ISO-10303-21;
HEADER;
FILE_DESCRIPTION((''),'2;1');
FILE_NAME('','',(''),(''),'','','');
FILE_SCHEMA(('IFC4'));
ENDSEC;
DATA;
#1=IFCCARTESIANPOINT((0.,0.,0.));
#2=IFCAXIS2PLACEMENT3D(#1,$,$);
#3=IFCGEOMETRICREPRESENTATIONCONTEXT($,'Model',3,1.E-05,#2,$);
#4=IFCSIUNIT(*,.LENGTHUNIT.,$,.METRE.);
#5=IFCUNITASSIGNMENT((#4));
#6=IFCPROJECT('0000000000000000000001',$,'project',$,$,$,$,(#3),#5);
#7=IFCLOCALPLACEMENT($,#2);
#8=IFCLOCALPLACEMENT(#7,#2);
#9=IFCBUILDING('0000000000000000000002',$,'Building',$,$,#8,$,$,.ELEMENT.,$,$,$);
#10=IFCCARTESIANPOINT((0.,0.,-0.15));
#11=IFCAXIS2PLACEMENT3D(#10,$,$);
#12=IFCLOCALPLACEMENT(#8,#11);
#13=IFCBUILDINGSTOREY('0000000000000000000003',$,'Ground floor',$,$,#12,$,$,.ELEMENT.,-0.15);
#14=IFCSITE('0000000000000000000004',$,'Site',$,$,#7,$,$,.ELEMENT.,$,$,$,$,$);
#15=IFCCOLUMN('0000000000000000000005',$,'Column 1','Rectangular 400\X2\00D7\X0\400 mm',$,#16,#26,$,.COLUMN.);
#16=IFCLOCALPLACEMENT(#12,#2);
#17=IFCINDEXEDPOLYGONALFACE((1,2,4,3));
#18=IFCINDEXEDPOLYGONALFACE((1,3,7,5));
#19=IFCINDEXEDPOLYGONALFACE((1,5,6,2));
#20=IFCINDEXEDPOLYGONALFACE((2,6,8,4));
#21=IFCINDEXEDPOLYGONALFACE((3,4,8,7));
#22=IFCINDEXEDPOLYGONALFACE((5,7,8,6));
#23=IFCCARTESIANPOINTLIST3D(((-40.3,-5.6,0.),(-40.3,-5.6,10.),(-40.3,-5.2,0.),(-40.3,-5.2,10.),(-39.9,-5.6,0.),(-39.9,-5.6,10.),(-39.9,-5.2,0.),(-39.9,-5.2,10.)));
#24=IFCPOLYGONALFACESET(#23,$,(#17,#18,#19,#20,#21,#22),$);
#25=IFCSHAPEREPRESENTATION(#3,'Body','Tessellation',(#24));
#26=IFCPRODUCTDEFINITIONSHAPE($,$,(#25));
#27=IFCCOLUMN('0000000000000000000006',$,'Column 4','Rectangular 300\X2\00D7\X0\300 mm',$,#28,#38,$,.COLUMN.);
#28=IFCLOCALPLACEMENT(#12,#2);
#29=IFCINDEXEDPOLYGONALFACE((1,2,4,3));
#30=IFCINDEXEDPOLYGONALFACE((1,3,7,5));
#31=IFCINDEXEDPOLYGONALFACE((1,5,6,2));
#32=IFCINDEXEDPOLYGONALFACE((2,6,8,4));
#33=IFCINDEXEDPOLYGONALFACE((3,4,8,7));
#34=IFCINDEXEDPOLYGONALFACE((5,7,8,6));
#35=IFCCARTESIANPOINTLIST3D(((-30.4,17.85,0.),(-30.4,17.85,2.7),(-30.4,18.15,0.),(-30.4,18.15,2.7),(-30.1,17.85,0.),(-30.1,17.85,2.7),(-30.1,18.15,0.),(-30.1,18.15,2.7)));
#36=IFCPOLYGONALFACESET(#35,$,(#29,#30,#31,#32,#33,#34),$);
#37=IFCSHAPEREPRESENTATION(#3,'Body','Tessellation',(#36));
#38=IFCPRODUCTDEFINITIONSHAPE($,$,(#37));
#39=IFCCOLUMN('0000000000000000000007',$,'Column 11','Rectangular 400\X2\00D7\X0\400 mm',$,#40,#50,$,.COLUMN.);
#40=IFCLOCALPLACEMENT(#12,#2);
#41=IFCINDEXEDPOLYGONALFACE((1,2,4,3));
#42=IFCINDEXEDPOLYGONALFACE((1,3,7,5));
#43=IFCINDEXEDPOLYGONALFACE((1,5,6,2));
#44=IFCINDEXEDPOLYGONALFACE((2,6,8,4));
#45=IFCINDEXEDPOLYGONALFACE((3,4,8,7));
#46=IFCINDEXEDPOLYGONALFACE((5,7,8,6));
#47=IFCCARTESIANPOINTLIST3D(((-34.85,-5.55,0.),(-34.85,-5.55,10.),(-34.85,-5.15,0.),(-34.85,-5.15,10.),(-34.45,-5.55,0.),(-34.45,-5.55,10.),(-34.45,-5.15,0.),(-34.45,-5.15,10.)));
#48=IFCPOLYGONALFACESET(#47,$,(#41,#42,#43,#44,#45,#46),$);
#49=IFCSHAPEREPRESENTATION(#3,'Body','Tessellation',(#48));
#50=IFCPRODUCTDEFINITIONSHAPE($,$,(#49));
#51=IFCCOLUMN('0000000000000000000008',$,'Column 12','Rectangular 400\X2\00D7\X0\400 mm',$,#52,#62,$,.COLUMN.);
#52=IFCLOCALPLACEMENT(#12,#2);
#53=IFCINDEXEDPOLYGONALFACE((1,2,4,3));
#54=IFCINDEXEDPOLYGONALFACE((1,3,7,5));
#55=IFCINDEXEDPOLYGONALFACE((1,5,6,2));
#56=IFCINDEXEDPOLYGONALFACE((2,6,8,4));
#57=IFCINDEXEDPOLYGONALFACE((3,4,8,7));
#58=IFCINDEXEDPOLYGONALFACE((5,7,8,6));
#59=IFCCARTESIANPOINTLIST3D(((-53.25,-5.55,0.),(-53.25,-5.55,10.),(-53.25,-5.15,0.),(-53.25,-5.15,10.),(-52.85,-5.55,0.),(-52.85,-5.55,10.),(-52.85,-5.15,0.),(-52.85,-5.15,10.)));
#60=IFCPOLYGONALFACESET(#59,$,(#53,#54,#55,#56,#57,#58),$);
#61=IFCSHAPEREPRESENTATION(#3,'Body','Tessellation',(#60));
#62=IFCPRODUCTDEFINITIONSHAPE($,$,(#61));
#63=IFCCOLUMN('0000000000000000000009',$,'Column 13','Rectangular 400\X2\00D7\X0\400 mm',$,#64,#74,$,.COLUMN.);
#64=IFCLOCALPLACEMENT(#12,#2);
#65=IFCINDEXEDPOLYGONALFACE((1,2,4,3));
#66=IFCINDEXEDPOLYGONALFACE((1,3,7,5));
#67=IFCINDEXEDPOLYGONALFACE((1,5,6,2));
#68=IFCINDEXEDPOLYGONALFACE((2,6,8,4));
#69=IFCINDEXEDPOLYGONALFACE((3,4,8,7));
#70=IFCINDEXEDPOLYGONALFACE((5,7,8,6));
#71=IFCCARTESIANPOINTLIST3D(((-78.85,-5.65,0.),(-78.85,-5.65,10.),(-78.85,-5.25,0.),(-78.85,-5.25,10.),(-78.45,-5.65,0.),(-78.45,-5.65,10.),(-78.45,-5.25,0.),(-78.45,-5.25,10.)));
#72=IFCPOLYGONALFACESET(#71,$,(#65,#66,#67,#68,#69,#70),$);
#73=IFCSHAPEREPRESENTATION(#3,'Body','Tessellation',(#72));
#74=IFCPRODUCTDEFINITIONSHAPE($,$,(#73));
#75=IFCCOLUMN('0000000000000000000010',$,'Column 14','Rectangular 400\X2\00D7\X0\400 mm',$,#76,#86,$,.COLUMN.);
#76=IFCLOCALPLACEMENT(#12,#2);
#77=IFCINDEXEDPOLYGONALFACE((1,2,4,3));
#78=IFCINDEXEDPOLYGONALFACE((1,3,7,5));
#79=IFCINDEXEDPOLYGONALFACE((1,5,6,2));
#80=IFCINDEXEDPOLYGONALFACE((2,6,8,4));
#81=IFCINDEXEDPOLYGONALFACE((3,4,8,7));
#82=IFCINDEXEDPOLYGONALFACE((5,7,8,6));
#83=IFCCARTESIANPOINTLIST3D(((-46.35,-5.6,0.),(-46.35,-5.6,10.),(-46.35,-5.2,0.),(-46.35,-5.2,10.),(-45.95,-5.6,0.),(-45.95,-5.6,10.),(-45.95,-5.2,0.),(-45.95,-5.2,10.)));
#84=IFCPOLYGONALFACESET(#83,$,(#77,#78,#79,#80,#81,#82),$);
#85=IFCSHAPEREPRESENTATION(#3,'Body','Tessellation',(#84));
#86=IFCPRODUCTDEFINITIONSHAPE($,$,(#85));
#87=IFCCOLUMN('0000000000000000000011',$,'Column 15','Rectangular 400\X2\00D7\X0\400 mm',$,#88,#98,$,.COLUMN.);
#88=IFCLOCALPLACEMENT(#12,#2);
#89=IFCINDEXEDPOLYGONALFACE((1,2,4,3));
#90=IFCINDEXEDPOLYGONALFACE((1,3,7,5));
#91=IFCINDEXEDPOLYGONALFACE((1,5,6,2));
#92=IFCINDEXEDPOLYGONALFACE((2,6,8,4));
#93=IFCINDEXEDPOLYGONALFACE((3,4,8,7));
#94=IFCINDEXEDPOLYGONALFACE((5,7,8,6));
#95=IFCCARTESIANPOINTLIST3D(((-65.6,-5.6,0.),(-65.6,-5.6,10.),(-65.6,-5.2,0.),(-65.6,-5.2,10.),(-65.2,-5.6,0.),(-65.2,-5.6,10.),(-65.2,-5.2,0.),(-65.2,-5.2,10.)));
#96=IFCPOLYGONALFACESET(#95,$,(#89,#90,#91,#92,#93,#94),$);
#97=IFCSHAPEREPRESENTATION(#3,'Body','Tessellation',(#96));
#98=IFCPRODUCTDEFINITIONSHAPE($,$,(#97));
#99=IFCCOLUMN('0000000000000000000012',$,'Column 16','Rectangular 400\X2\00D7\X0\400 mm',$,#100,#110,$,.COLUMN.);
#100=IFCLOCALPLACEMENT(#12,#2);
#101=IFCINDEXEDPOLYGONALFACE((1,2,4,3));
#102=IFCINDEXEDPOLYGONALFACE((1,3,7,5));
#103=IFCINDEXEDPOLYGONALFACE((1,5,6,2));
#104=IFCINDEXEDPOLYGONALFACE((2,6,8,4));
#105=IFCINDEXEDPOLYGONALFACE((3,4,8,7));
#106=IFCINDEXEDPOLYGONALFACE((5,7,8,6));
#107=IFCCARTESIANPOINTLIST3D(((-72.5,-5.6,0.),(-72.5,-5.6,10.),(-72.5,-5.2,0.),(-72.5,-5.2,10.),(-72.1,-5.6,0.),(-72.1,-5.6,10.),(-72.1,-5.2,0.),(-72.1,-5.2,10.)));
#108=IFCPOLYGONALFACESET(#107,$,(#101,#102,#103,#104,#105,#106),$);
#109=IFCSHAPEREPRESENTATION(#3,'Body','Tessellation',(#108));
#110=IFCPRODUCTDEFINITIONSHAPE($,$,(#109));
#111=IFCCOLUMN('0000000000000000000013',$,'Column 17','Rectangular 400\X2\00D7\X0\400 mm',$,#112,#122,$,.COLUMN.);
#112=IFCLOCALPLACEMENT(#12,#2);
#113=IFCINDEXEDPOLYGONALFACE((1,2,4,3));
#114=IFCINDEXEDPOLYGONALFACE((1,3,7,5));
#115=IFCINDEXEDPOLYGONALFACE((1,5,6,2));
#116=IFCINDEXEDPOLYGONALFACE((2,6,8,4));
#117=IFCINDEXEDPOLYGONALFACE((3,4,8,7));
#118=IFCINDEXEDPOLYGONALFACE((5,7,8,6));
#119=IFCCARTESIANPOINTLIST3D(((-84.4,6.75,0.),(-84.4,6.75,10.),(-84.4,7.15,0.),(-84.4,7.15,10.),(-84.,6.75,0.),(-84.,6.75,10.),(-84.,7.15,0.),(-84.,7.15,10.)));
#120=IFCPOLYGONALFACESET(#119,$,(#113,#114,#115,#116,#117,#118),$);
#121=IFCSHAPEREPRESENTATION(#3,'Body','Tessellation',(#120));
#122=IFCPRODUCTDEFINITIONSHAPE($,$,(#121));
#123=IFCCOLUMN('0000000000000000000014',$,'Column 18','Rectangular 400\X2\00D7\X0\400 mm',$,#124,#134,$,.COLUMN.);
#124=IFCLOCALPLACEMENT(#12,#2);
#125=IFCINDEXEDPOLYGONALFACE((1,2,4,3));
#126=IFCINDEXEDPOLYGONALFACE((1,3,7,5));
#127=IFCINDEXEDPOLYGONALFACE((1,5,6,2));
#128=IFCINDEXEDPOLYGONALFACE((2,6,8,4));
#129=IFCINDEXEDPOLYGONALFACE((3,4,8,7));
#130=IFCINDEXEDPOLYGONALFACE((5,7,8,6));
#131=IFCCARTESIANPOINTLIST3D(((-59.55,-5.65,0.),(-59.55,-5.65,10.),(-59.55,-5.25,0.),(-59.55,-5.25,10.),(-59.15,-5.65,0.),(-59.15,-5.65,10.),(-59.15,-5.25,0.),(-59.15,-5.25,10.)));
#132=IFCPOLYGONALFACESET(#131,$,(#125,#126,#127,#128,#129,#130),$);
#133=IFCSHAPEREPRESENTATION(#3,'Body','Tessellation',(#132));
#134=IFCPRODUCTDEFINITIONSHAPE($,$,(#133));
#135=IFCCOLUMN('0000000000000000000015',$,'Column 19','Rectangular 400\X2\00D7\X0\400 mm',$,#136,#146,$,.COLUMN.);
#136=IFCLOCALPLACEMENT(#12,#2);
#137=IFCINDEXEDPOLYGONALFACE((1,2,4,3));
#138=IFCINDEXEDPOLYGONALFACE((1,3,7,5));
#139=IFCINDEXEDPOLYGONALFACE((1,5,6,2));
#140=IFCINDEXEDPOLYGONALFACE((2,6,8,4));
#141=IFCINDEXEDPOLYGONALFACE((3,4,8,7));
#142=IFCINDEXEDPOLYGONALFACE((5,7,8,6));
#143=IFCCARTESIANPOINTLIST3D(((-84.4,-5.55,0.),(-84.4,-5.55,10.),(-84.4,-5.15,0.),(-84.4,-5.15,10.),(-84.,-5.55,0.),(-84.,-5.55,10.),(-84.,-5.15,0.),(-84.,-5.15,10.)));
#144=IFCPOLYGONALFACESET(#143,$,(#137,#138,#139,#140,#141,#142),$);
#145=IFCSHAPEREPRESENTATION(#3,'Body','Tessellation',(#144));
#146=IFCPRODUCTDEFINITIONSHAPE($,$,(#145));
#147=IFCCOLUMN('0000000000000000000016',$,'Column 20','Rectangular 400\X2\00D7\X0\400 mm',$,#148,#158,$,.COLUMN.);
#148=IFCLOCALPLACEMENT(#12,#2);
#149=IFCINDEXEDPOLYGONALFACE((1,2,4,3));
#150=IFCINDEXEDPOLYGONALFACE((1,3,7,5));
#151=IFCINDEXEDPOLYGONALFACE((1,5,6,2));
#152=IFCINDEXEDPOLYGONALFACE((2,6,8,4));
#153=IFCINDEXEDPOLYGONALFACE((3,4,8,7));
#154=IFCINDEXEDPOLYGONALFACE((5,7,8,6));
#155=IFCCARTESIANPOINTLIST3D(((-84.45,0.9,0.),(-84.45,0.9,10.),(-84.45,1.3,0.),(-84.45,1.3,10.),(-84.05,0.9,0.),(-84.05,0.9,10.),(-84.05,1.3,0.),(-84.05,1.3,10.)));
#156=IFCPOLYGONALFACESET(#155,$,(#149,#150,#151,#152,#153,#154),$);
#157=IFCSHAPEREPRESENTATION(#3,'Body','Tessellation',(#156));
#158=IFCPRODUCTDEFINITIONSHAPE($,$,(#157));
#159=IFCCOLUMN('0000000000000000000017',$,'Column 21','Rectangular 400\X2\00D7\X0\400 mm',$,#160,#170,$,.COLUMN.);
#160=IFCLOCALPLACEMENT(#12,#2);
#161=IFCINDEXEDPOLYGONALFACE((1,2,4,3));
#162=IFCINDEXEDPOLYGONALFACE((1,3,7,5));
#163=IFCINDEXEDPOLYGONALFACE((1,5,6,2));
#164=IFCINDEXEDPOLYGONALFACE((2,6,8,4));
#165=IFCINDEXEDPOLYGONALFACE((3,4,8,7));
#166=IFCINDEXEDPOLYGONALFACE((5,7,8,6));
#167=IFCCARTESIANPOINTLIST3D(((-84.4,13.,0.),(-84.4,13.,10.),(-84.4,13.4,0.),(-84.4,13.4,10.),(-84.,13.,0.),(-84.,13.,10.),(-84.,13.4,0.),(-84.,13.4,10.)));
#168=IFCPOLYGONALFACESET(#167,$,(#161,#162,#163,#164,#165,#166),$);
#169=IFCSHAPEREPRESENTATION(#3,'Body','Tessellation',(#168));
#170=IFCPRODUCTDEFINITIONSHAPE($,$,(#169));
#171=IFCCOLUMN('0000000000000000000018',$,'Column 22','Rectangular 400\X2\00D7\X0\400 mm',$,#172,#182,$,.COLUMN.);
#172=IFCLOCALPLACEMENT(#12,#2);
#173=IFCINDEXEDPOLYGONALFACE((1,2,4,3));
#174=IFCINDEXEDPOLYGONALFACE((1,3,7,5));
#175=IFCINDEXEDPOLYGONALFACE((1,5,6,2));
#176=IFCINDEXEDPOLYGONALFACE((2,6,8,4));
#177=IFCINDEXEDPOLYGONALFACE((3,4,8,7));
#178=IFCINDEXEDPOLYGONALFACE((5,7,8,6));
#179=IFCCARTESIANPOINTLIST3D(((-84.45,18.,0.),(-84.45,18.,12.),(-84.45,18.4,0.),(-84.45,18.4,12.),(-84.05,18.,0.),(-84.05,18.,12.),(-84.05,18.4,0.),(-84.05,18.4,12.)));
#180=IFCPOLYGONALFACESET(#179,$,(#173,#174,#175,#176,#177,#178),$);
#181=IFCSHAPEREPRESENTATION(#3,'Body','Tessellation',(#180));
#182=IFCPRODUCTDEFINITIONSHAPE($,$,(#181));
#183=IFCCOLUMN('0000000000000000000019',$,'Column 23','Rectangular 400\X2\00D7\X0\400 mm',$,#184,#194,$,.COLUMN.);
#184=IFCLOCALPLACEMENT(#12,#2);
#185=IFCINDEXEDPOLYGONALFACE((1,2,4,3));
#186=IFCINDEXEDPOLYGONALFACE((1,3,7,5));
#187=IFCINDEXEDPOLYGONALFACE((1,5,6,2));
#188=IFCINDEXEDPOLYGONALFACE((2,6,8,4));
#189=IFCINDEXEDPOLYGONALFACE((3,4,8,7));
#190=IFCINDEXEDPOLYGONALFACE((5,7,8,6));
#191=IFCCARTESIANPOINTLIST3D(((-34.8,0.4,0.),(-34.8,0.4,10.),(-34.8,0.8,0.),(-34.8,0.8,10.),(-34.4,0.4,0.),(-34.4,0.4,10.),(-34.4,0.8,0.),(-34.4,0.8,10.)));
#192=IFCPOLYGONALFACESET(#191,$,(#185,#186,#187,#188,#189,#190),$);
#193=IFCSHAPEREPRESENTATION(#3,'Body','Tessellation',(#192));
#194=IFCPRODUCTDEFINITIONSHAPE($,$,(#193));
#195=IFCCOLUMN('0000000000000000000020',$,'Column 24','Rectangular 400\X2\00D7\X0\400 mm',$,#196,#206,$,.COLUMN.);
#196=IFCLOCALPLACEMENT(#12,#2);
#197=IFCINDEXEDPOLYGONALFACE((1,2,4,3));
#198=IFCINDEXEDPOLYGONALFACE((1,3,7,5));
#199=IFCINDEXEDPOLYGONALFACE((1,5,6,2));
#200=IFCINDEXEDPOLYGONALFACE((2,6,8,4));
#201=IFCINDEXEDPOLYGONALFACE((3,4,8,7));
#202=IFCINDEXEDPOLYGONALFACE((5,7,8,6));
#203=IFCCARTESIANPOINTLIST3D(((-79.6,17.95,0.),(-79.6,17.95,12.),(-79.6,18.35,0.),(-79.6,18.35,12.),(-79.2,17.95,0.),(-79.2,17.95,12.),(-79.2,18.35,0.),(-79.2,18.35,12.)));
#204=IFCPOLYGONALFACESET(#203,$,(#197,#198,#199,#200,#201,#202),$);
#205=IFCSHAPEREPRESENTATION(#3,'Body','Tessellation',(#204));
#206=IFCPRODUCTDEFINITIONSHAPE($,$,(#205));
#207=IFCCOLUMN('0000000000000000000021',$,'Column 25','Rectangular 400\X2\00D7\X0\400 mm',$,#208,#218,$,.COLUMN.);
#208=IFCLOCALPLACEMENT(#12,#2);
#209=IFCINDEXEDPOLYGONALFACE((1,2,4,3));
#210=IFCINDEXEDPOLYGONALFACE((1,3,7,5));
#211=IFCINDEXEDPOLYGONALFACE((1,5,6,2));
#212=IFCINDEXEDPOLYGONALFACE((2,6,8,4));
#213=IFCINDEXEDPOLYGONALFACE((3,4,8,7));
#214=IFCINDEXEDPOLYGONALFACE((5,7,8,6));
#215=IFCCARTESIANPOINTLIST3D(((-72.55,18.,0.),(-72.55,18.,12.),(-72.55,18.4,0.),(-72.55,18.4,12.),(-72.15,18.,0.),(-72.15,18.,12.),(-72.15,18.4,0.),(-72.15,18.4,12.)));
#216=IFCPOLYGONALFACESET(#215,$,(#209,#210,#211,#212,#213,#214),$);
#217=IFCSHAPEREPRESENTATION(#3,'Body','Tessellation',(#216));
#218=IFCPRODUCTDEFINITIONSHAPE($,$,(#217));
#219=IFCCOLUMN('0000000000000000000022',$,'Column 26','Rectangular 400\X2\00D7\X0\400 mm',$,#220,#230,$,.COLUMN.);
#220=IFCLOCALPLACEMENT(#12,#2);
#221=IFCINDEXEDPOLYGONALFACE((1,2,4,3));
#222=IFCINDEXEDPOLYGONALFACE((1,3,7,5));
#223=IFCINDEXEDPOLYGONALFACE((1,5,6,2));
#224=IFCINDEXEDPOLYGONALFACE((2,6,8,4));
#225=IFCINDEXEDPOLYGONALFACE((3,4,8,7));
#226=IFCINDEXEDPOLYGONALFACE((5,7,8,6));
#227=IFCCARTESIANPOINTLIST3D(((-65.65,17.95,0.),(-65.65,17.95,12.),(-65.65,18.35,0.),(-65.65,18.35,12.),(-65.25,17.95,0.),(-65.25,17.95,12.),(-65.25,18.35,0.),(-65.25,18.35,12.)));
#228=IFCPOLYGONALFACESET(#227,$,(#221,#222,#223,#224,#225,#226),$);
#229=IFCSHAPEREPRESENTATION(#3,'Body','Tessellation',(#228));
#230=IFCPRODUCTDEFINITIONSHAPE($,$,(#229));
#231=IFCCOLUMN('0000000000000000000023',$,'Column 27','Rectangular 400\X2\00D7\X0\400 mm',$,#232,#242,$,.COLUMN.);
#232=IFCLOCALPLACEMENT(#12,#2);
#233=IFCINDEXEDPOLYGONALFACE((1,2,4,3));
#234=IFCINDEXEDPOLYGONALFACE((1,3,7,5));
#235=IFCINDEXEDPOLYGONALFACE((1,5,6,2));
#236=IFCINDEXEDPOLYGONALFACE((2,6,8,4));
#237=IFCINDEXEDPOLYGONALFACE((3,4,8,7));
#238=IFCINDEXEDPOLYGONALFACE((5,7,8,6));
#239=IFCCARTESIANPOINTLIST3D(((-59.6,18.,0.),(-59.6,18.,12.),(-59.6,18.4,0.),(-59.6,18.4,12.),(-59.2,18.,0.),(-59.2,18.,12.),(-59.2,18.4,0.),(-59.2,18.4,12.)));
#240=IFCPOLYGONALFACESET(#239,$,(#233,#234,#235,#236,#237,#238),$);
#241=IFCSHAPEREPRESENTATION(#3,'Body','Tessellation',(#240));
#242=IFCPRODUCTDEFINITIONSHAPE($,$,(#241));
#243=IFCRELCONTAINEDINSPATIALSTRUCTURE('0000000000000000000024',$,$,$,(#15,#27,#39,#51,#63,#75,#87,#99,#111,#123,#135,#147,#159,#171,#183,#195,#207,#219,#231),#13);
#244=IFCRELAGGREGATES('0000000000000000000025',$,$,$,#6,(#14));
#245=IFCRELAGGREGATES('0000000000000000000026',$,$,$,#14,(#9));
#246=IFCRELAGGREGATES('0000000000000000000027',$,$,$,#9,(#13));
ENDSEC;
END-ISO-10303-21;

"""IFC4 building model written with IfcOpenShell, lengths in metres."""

from ifc_helpers import new_model, si_unit, frame, origin, place, context, project, spatial, polyline, outline, extrude, element, save


model = new_model("IFC4")

# Units and contexts
model_context = context("Model", 3, precision=1e-05, world=origin())
ifc_project = project(units=[si_unit("LENGTHUNIT", "METRE")], contexts=[model_context])

# Site, building, storey
site_placement = place(None, origin())
site = spatial("IfcSite", under=ifc_project, at=site_placement, Name="Site", CompositionType="ELEMENT")
building_placement = place(site_placement, origin())
building = spatial("IfcBuilding", under=site, at=building_placement, Name="Building", CompositionType="ELEMENT")
storey_placement = place(building_placement, frame((0.0, 0.0, -0.15)))
storey = spatial("IfcBuildingStorey", under=building, at=storey_placement, Name="Ground floor", CompositionType="ELEMENT", Elevation=-0.15)

# Columns
column_1_placement = place(storey_placement, frame((-40.1, -5.4, 0.0), z_axis=(0.0, 0.0, 1.0), x_axis=(1.0, 0.0, 0.0)))
element("IfcColumn", 1, at=column_1_placement, inside=storey, Name="Column 1", Description="Rectangular 400×400 mm", PredefinedType="COLUMN", context=model_context, shape_type="SweptSolid", body=[
    extrude(outline(polyline([(-0.2, -0.2), (0.2, -0.2), (0.2, 0.2), (-0.2, 0.2), (-0.2, -0.2)])), origin(), (0.0, 0.0, 1.0), 10.0),
])
column_2_placement = place(storey_placement, frame((-30.25, 18.0, 0.0), z_axis=(0.0, 0.0, 1.0), x_axis=(1.0, 0.0, 0.0)))
element("IfcColumn", 2, at=column_2_placement, inside=storey, Name="Column 4", Description="Rectangular 300×300 mm", PredefinedType="COLUMN", context=model_context, shape_type="SweptSolid", body=[
    extrude(outline(polyline([(-0.15, -0.15), (0.15, -0.15), (0.15, 0.15), (-0.15, 0.15), (-0.15, -0.15)])), origin(), (0.0, 0.0, 1.0), 2.7),
])
for number, where, z_axis, x_axis, name in (
    (3, (-34.65, -5.35, 0.0), (0.0, 0.0, 1.0), (1.0, 0.0, 0.0), "Column 11"),
    (4, (-53.05, -5.35, 0.0), (0.0, 0.0, 1.0), (1.0, 0.0, 0.0), "Column 12"),
    (5, (-78.65, -5.45, 0.0), (0.0, 0.0, 1.0), (1.0, 0.0, 0.0), "Column 13"),
    (6, (-46.15, -5.4, 0.0), (0.0, 0.0, 1.0), (1.0, 0.0, 0.0), "Column 14"),
    (7, (-65.4, -5.4, 0.0), (0.0, 0.0, 1.0), (1.0, 0.0, 0.0), "Column 15"),
    (8, (-72.3, -5.4, 0.0), (0.0, 0.0, 1.0), (1.0, 0.0, 0.0), "Column 16"),
    (9, (-84.2, 6.95, 0.0), (0.0, 0.0, 1.0), (1.0, 0.0, 0.0), "Column 17"),
    (10, (-59.35, -5.45, 0.0), (0.0, 0.0, 1.0), (1.0, 0.0, 0.0), "Column 18"),
    (11, (-84.2, -5.35, 0.0), (0.0, 0.0, 1.0), (1.0, 0.0, 0.0), "Column 19"),
    (12, (-84.25, 1.1, 0.0), (0.0, 0.0, 1.0), (1.0, 0.0, 0.0), "Column 20"),
    (13, (-84.2, 13.2, 0.0), (0.0, 0.0, 1.0), (1.0, 0.0, 0.0), "Column 21"),
):
    element("IfcColumn", number, at=place(storey_placement, frame(where, z_axis=z_axis, x_axis=x_axis)), inside=storey, Name=name, Description="Rectangular 400×400 mm", PredefinedType="COLUMN", context=model_context, shape_type="SweptSolid", body=[
        extrude(outline(polyline([(-0.2, -0.2), (0.2, -0.2), (0.2, 0.2), (-0.2, 0.2), (-0.2, -0.2)])), origin(), (0.0, 0.0, 1.0), 10.0),
    ])
column_3_placement = place(storey_placement, frame((-84.25, 18.2, 0.0), z_axis=(0.0, 0.0, 1.0), x_axis=(1.0, 0.0, 0.0)))
element("IfcColumn", 14, at=column_3_placement, inside=storey, Name="Column 22", Description="Rectangular 400×400 mm", PredefinedType="COLUMN", context=model_context, shape_type="SweptSolid", body=[
    extrude(outline(polyline([(-0.2, -0.2), (0.2, -0.2), (0.2, 0.2), (-0.2, 0.2), (-0.2, -0.2)])), origin(), (0.0, 0.0, 1.0), 12.0),
])
column_4_placement = place(storey_placement, frame((-34.6, 0.6, 0.0), z_axis=(0.0, 0.0, 1.0), x_axis=(1.0, 0.0, 0.0)))
element("IfcColumn", 15, at=column_4_placement, inside=storey, Name="Column 23", Description="Rectangular 400×400 mm", PredefinedType="COLUMN", context=model_context, shape_type="SweptSolid", body=[
    extrude(outline(polyline([(-0.2, -0.2), (0.2, -0.2), (0.2, 0.2), (-0.2, 0.2), (-0.2, -0.2)])), origin(), (0.0, 0.0, 1.0), 10.0),
])
for number, where, z_axis, x_axis, name in (
    (16, (-79.4, 18.15, 0.0), (0.0, 0.0, 1.0), (1.0, 0.0, 0.0), "Column 24"),
    (17, (-72.35, 18.2, 0.0), (0.0, 0.0, 1.0), (1.0, 0.0, 0.0), "Column 25"),
    (18, (-65.45, 18.15, 0.0), (0.0, 0.0, 1.0), (1.0, 0.0, 0.0), "Column 26"),
    (19, (-59.4, 18.2, 0.0), (0.0, 0.0, 1.0), (1.0, 0.0, 0.0), "Column 27"),
):
    element("IfcColumn", number, at=place(storey_placement, frame(where, z_axis=z_axis, x_axis=x_axis)), inside=storey, Name=name, Description="Rectangular 400×400 mm", PredefinedType="COLUMN", context=model_context, shape_type="SweptSolid", body=[
        extrude(outline(polyline([(-0.2, -0.2), (0.2, -0.2), (0.2, 0.2), (-0.2, 0.2), (-0.2, -0.2)])), origin(), (0.0, 0.0, 1.0), 12.0),
    ])

save(model, "model.ifc")
